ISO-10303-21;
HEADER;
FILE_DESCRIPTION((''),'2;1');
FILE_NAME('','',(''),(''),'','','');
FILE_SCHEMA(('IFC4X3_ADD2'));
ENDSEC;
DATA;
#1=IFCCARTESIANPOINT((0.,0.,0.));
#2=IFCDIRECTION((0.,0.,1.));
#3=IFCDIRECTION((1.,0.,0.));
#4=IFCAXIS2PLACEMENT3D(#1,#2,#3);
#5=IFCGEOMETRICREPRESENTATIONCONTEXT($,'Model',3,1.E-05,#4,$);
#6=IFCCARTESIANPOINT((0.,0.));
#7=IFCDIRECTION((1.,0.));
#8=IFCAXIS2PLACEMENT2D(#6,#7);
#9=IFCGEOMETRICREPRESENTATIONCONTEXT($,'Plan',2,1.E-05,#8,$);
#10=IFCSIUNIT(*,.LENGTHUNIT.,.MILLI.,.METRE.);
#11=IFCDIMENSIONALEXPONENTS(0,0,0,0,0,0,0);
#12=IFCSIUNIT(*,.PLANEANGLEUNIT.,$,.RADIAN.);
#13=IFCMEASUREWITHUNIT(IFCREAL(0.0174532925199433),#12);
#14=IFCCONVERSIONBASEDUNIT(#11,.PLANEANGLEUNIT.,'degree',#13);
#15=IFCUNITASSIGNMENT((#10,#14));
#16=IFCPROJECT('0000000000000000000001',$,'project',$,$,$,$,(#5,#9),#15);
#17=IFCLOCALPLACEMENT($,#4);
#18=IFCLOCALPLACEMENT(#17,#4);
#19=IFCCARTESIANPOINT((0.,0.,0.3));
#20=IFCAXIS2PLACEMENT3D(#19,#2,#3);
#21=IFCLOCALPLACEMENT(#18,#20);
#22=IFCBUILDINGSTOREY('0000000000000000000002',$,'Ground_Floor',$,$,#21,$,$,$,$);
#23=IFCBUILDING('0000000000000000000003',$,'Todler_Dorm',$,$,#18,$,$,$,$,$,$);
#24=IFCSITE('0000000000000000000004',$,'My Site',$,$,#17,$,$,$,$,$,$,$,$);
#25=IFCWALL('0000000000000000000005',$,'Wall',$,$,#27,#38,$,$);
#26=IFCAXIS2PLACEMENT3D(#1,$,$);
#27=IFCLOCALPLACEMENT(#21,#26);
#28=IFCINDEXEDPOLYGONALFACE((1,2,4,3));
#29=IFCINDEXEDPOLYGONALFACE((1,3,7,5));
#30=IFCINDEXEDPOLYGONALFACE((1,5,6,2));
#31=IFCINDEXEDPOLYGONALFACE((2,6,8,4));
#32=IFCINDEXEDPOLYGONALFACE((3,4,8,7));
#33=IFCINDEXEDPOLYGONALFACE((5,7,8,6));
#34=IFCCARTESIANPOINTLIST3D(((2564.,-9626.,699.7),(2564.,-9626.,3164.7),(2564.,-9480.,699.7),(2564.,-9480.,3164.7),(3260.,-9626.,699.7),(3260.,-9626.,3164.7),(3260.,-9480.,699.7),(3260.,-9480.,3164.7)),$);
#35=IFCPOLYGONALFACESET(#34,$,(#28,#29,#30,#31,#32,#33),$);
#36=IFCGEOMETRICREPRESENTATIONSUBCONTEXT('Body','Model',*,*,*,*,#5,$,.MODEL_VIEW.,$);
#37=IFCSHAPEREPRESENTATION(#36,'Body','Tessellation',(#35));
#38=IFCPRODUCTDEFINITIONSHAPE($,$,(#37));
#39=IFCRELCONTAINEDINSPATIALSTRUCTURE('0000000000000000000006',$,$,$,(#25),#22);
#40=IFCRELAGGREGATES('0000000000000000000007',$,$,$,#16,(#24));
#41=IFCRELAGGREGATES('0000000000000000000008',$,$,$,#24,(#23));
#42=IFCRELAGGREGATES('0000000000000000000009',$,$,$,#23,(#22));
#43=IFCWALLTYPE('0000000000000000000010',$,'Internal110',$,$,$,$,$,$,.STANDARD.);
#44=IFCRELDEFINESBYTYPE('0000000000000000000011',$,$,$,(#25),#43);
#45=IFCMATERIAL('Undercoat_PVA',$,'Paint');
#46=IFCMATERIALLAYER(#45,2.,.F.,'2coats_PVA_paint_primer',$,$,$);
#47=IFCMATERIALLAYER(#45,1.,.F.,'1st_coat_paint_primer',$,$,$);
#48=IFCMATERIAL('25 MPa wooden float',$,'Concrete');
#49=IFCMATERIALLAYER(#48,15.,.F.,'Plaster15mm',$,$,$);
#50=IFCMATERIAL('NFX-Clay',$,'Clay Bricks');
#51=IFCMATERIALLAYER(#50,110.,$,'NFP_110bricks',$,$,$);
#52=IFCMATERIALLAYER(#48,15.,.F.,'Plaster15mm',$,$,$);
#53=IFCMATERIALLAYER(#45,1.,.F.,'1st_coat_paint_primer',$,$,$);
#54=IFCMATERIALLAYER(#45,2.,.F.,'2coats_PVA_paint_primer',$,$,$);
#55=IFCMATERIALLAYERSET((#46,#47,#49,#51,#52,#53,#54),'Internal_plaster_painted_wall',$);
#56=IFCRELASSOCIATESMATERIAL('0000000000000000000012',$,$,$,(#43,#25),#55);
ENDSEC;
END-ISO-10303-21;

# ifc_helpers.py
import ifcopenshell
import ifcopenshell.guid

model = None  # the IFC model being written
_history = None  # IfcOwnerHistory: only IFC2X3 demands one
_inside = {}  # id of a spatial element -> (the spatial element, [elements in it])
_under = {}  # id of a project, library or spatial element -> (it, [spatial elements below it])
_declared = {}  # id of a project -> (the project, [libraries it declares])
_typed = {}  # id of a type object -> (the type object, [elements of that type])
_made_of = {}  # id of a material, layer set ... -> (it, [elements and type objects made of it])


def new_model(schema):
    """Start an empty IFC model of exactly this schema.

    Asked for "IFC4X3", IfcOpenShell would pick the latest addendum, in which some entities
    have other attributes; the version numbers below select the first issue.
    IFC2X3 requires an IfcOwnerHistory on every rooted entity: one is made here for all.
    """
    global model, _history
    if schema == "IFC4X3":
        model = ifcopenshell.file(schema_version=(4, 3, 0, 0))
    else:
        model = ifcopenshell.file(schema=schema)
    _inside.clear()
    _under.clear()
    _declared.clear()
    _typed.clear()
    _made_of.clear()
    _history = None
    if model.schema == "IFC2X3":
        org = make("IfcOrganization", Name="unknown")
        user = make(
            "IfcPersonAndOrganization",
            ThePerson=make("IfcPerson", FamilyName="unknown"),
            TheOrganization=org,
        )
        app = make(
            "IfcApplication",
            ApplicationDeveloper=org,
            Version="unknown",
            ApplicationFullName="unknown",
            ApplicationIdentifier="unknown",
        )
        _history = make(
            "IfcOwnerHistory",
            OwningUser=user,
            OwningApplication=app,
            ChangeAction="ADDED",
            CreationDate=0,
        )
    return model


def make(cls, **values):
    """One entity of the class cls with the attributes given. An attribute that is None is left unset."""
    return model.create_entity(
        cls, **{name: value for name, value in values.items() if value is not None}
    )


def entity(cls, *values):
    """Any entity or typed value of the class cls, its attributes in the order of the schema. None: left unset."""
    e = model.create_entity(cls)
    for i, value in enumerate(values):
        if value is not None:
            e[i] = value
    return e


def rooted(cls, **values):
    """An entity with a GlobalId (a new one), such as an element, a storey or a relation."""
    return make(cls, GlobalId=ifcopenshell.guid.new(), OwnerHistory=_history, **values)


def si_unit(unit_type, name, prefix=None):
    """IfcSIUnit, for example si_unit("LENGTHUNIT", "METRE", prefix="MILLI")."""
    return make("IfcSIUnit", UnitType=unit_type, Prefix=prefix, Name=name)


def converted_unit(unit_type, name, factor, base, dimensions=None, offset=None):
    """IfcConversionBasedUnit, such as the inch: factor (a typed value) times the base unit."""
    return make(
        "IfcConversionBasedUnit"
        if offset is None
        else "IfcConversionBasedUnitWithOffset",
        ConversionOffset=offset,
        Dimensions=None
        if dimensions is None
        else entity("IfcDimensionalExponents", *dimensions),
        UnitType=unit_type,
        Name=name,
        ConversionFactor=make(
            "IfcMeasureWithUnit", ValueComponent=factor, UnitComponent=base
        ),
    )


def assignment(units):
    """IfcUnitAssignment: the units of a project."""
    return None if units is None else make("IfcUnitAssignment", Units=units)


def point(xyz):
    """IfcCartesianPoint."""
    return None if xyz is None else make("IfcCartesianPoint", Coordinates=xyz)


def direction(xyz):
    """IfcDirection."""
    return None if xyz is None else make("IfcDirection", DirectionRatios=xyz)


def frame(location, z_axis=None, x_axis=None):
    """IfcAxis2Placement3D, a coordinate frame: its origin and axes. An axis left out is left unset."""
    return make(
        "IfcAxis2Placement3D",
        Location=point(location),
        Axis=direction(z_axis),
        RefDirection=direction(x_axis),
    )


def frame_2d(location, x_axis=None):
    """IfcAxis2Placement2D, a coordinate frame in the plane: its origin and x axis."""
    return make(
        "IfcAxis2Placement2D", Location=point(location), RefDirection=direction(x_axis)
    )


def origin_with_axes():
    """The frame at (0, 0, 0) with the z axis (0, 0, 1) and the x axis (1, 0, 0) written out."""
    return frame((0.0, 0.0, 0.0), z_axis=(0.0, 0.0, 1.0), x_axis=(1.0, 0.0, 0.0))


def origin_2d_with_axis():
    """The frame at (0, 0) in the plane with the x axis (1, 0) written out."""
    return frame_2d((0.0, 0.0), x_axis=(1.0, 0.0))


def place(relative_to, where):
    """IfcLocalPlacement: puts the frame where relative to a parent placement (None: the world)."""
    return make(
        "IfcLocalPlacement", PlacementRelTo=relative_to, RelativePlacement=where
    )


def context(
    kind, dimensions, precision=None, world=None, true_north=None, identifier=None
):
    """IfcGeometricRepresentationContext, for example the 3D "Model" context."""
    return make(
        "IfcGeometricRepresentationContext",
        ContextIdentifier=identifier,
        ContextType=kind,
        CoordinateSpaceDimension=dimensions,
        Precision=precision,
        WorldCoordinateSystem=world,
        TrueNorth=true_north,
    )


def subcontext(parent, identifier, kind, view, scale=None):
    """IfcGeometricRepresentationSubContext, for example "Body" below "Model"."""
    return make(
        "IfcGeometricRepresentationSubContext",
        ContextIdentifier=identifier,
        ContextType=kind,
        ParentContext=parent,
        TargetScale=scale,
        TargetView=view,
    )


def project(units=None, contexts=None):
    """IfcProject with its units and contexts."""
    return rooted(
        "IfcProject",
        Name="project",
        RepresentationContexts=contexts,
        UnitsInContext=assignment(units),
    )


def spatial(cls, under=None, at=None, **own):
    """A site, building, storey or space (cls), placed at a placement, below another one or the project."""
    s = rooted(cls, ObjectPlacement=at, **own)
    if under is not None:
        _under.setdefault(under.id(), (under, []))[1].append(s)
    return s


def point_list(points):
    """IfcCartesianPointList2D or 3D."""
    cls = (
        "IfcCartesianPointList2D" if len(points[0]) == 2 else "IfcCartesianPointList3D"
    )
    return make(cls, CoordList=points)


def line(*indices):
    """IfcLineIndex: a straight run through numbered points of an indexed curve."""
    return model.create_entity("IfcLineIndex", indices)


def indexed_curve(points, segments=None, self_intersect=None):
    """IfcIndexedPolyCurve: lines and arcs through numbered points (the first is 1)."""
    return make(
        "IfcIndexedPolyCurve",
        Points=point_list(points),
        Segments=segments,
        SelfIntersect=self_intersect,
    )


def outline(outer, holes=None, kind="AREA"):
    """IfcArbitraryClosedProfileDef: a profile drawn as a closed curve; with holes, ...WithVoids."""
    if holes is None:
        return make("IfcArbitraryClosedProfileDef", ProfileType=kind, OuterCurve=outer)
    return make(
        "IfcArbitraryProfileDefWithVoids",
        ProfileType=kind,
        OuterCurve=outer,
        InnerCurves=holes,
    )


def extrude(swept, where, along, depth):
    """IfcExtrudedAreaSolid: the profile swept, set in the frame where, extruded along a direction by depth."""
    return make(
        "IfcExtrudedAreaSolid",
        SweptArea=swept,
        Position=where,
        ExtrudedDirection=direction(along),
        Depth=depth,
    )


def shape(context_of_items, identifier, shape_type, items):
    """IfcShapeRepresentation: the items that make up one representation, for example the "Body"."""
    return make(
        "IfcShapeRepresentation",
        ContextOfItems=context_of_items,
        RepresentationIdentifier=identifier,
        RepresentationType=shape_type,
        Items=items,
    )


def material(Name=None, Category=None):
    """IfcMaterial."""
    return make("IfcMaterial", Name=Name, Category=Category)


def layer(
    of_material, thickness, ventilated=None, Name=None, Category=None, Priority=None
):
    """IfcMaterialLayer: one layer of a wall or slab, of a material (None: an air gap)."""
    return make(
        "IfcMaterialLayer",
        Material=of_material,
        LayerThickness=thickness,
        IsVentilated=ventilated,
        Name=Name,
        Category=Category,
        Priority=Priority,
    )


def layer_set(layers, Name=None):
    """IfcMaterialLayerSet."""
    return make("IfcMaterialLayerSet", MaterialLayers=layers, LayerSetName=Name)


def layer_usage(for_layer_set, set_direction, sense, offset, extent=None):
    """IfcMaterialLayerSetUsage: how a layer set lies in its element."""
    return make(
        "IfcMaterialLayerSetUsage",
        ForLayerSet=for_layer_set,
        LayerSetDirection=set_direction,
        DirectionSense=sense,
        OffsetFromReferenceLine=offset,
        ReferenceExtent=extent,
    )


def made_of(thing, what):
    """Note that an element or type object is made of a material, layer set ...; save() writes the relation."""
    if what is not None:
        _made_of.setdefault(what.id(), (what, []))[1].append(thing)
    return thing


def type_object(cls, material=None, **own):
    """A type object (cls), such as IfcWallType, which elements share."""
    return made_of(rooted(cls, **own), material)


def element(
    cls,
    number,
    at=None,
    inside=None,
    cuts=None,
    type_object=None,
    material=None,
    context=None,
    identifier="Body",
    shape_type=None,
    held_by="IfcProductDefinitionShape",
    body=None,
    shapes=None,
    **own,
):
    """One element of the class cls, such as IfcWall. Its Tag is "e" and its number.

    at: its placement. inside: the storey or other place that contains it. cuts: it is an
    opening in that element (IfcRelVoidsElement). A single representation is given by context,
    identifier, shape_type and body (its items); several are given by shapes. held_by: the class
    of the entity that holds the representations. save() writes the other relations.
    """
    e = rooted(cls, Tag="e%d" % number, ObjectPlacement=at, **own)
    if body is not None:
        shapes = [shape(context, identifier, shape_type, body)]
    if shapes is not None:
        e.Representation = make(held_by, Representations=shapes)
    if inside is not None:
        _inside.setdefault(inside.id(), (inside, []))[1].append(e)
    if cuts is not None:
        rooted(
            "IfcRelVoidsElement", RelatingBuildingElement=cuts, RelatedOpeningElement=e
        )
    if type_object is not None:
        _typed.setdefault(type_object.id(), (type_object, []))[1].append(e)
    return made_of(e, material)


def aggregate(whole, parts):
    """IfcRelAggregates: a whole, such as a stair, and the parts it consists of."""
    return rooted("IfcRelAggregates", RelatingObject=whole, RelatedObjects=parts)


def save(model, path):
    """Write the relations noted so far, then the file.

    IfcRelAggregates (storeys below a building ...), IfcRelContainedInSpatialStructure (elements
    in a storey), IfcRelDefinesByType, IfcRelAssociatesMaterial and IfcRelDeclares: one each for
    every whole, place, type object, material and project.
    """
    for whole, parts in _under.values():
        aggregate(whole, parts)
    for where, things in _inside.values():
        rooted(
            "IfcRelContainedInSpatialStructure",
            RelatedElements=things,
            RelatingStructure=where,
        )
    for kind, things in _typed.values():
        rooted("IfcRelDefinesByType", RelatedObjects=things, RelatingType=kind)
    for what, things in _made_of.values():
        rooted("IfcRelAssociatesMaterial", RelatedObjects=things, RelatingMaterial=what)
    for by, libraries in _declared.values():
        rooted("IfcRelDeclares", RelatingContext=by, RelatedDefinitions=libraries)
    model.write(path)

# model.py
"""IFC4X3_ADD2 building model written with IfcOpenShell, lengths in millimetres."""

from ifc_helpers import new_model, entity, si_unit, converted_unit, frame, origin_with_axes, origin_2d_with_axis, place, context, subcontext, project, spatial, line, indexed_curve, outline, extrude, material, layer, layer_set, layer_usage, type_object, element, save


model = new_model("IFC4X3_ADD2")

# Units and contexts
model_context = context("Model", 3, precision=1e-05, world=origin_with_axes())
plan_context = context("Plan", 2, precision=1e-05, world=origin_2d_with_axis())
body_context_1 = subcontext(model_context, "Body", "Model", "MODEL_VIEW")
ifc_project = project(units=[si_unit("LENGTHUNIT", "METRE", prefix="MILLI"), converted_unit("PLANEANGLEUNIT", "degree", entity("IfcReal", 0.0174532925199433), si_unit("PLANEANGLEUNIT", "RADIAN"), dimensions=[0, 0, 0, 0, 0, 0, 0])], contexts=[model_context, plan_context])

# Site, building, storey
site_placement = place(None, origin_with_axes())
site = spatial("IfcSite", under=ifc_project, at=site_placement, Name="My Site")
building_placement = place(site_placement, origin_with_axes())
building = spatial("IfcBuilding", under=site, at=building_placement, Name="Todler_Dorm")
storey_placement = place(building_placement, frame((0.0, 0.0, 0.3), z_axis=(0.0, 0.0, 1.0), x_axis=(1.0, 0.0, 0.0)))
storey = spatial("IfcBuildingStorey", under=building, at=storey_placement, Name="Ground_Floor")

# Shared definitions
ifc_material_1 = material(Name="Undercoat_PVA", Category="Paint")
ifc_layer_1 = layer(ifc_material_1, 2.0, ventilated=False, Name="2coats_PVA_paint_primer")
ifc_layer_2 = layer(ifc_material_1, 1.0, ventilated=False, Name="1st_coat_paint_primer")
ifc_material_2 = material(Name="25 MPa wooden float", Category="Concrete")
ifc_layer_3 = layer(ifc_material_2, 15.0, ventilated=False, Name="Plaster15mm")
ifc_material_3 = material(Name="NFX-Clay", Category="Clay Bricks")
ifc_layer_4 = layer(ifc_material_3, 110.0, Name="NFP_110bricks")
ifc_layer_5 = layer(ifc_material_2, 15.0, ventilated=False, Name="Plaster15mm")
ifc_layer_6 = layer(ifc_material_1, 1.0, ventilated=False, Name="1st_coat_paint_primer")
ifc_layer_7 = layer(ifc_material_1, 2.0, ventilated=False, Name="2coats_PVA_paint_primer")
ifc_layer_set_1 = layer_set([ifc_layer_1, ifc_layer_2, ifc_layer_3, ifc_layer_4, ifc_layer_5, ifc_layer_6, ifc_layer_7], Name="Internal_plaster_painted_wall")
wall_type_1 = type_object("IfcWallType", Name="Internal110", PredefinedType="STANDARD", material=ifc_layer_set_1)

# Wall
ifc_layer_usage_1 = layer_usage(ifc_layer_set_1, "AXIS2", "POSITIVE", 0.0)
wall_1_placement = place(storey_placement, frame((3260.0, -9480.0, 699.7), z_axis=(0.0, 0.0, 1.0), x_axis=(-1.0, 0.0, 0.0)))
element("IfcWall", 1, at=wall_1_placement, inside=storey, type_object=wall_type_1, material=ifc_layer_usage_1, Name="Wall", context=body_context_1, shape_type="SweptSolid", body=[
    extrude(outline(indexed_curve([(0.0, 0.0), (0.0, 146.0), (696.0, 146.0), (696.0, 0.0)], segments=[line(1, 2, 3, 4, 1)])), origin_with_axes(), (0.0, 0.0, 1.0), 2465.0),
])

save(model, "model.ifc")
